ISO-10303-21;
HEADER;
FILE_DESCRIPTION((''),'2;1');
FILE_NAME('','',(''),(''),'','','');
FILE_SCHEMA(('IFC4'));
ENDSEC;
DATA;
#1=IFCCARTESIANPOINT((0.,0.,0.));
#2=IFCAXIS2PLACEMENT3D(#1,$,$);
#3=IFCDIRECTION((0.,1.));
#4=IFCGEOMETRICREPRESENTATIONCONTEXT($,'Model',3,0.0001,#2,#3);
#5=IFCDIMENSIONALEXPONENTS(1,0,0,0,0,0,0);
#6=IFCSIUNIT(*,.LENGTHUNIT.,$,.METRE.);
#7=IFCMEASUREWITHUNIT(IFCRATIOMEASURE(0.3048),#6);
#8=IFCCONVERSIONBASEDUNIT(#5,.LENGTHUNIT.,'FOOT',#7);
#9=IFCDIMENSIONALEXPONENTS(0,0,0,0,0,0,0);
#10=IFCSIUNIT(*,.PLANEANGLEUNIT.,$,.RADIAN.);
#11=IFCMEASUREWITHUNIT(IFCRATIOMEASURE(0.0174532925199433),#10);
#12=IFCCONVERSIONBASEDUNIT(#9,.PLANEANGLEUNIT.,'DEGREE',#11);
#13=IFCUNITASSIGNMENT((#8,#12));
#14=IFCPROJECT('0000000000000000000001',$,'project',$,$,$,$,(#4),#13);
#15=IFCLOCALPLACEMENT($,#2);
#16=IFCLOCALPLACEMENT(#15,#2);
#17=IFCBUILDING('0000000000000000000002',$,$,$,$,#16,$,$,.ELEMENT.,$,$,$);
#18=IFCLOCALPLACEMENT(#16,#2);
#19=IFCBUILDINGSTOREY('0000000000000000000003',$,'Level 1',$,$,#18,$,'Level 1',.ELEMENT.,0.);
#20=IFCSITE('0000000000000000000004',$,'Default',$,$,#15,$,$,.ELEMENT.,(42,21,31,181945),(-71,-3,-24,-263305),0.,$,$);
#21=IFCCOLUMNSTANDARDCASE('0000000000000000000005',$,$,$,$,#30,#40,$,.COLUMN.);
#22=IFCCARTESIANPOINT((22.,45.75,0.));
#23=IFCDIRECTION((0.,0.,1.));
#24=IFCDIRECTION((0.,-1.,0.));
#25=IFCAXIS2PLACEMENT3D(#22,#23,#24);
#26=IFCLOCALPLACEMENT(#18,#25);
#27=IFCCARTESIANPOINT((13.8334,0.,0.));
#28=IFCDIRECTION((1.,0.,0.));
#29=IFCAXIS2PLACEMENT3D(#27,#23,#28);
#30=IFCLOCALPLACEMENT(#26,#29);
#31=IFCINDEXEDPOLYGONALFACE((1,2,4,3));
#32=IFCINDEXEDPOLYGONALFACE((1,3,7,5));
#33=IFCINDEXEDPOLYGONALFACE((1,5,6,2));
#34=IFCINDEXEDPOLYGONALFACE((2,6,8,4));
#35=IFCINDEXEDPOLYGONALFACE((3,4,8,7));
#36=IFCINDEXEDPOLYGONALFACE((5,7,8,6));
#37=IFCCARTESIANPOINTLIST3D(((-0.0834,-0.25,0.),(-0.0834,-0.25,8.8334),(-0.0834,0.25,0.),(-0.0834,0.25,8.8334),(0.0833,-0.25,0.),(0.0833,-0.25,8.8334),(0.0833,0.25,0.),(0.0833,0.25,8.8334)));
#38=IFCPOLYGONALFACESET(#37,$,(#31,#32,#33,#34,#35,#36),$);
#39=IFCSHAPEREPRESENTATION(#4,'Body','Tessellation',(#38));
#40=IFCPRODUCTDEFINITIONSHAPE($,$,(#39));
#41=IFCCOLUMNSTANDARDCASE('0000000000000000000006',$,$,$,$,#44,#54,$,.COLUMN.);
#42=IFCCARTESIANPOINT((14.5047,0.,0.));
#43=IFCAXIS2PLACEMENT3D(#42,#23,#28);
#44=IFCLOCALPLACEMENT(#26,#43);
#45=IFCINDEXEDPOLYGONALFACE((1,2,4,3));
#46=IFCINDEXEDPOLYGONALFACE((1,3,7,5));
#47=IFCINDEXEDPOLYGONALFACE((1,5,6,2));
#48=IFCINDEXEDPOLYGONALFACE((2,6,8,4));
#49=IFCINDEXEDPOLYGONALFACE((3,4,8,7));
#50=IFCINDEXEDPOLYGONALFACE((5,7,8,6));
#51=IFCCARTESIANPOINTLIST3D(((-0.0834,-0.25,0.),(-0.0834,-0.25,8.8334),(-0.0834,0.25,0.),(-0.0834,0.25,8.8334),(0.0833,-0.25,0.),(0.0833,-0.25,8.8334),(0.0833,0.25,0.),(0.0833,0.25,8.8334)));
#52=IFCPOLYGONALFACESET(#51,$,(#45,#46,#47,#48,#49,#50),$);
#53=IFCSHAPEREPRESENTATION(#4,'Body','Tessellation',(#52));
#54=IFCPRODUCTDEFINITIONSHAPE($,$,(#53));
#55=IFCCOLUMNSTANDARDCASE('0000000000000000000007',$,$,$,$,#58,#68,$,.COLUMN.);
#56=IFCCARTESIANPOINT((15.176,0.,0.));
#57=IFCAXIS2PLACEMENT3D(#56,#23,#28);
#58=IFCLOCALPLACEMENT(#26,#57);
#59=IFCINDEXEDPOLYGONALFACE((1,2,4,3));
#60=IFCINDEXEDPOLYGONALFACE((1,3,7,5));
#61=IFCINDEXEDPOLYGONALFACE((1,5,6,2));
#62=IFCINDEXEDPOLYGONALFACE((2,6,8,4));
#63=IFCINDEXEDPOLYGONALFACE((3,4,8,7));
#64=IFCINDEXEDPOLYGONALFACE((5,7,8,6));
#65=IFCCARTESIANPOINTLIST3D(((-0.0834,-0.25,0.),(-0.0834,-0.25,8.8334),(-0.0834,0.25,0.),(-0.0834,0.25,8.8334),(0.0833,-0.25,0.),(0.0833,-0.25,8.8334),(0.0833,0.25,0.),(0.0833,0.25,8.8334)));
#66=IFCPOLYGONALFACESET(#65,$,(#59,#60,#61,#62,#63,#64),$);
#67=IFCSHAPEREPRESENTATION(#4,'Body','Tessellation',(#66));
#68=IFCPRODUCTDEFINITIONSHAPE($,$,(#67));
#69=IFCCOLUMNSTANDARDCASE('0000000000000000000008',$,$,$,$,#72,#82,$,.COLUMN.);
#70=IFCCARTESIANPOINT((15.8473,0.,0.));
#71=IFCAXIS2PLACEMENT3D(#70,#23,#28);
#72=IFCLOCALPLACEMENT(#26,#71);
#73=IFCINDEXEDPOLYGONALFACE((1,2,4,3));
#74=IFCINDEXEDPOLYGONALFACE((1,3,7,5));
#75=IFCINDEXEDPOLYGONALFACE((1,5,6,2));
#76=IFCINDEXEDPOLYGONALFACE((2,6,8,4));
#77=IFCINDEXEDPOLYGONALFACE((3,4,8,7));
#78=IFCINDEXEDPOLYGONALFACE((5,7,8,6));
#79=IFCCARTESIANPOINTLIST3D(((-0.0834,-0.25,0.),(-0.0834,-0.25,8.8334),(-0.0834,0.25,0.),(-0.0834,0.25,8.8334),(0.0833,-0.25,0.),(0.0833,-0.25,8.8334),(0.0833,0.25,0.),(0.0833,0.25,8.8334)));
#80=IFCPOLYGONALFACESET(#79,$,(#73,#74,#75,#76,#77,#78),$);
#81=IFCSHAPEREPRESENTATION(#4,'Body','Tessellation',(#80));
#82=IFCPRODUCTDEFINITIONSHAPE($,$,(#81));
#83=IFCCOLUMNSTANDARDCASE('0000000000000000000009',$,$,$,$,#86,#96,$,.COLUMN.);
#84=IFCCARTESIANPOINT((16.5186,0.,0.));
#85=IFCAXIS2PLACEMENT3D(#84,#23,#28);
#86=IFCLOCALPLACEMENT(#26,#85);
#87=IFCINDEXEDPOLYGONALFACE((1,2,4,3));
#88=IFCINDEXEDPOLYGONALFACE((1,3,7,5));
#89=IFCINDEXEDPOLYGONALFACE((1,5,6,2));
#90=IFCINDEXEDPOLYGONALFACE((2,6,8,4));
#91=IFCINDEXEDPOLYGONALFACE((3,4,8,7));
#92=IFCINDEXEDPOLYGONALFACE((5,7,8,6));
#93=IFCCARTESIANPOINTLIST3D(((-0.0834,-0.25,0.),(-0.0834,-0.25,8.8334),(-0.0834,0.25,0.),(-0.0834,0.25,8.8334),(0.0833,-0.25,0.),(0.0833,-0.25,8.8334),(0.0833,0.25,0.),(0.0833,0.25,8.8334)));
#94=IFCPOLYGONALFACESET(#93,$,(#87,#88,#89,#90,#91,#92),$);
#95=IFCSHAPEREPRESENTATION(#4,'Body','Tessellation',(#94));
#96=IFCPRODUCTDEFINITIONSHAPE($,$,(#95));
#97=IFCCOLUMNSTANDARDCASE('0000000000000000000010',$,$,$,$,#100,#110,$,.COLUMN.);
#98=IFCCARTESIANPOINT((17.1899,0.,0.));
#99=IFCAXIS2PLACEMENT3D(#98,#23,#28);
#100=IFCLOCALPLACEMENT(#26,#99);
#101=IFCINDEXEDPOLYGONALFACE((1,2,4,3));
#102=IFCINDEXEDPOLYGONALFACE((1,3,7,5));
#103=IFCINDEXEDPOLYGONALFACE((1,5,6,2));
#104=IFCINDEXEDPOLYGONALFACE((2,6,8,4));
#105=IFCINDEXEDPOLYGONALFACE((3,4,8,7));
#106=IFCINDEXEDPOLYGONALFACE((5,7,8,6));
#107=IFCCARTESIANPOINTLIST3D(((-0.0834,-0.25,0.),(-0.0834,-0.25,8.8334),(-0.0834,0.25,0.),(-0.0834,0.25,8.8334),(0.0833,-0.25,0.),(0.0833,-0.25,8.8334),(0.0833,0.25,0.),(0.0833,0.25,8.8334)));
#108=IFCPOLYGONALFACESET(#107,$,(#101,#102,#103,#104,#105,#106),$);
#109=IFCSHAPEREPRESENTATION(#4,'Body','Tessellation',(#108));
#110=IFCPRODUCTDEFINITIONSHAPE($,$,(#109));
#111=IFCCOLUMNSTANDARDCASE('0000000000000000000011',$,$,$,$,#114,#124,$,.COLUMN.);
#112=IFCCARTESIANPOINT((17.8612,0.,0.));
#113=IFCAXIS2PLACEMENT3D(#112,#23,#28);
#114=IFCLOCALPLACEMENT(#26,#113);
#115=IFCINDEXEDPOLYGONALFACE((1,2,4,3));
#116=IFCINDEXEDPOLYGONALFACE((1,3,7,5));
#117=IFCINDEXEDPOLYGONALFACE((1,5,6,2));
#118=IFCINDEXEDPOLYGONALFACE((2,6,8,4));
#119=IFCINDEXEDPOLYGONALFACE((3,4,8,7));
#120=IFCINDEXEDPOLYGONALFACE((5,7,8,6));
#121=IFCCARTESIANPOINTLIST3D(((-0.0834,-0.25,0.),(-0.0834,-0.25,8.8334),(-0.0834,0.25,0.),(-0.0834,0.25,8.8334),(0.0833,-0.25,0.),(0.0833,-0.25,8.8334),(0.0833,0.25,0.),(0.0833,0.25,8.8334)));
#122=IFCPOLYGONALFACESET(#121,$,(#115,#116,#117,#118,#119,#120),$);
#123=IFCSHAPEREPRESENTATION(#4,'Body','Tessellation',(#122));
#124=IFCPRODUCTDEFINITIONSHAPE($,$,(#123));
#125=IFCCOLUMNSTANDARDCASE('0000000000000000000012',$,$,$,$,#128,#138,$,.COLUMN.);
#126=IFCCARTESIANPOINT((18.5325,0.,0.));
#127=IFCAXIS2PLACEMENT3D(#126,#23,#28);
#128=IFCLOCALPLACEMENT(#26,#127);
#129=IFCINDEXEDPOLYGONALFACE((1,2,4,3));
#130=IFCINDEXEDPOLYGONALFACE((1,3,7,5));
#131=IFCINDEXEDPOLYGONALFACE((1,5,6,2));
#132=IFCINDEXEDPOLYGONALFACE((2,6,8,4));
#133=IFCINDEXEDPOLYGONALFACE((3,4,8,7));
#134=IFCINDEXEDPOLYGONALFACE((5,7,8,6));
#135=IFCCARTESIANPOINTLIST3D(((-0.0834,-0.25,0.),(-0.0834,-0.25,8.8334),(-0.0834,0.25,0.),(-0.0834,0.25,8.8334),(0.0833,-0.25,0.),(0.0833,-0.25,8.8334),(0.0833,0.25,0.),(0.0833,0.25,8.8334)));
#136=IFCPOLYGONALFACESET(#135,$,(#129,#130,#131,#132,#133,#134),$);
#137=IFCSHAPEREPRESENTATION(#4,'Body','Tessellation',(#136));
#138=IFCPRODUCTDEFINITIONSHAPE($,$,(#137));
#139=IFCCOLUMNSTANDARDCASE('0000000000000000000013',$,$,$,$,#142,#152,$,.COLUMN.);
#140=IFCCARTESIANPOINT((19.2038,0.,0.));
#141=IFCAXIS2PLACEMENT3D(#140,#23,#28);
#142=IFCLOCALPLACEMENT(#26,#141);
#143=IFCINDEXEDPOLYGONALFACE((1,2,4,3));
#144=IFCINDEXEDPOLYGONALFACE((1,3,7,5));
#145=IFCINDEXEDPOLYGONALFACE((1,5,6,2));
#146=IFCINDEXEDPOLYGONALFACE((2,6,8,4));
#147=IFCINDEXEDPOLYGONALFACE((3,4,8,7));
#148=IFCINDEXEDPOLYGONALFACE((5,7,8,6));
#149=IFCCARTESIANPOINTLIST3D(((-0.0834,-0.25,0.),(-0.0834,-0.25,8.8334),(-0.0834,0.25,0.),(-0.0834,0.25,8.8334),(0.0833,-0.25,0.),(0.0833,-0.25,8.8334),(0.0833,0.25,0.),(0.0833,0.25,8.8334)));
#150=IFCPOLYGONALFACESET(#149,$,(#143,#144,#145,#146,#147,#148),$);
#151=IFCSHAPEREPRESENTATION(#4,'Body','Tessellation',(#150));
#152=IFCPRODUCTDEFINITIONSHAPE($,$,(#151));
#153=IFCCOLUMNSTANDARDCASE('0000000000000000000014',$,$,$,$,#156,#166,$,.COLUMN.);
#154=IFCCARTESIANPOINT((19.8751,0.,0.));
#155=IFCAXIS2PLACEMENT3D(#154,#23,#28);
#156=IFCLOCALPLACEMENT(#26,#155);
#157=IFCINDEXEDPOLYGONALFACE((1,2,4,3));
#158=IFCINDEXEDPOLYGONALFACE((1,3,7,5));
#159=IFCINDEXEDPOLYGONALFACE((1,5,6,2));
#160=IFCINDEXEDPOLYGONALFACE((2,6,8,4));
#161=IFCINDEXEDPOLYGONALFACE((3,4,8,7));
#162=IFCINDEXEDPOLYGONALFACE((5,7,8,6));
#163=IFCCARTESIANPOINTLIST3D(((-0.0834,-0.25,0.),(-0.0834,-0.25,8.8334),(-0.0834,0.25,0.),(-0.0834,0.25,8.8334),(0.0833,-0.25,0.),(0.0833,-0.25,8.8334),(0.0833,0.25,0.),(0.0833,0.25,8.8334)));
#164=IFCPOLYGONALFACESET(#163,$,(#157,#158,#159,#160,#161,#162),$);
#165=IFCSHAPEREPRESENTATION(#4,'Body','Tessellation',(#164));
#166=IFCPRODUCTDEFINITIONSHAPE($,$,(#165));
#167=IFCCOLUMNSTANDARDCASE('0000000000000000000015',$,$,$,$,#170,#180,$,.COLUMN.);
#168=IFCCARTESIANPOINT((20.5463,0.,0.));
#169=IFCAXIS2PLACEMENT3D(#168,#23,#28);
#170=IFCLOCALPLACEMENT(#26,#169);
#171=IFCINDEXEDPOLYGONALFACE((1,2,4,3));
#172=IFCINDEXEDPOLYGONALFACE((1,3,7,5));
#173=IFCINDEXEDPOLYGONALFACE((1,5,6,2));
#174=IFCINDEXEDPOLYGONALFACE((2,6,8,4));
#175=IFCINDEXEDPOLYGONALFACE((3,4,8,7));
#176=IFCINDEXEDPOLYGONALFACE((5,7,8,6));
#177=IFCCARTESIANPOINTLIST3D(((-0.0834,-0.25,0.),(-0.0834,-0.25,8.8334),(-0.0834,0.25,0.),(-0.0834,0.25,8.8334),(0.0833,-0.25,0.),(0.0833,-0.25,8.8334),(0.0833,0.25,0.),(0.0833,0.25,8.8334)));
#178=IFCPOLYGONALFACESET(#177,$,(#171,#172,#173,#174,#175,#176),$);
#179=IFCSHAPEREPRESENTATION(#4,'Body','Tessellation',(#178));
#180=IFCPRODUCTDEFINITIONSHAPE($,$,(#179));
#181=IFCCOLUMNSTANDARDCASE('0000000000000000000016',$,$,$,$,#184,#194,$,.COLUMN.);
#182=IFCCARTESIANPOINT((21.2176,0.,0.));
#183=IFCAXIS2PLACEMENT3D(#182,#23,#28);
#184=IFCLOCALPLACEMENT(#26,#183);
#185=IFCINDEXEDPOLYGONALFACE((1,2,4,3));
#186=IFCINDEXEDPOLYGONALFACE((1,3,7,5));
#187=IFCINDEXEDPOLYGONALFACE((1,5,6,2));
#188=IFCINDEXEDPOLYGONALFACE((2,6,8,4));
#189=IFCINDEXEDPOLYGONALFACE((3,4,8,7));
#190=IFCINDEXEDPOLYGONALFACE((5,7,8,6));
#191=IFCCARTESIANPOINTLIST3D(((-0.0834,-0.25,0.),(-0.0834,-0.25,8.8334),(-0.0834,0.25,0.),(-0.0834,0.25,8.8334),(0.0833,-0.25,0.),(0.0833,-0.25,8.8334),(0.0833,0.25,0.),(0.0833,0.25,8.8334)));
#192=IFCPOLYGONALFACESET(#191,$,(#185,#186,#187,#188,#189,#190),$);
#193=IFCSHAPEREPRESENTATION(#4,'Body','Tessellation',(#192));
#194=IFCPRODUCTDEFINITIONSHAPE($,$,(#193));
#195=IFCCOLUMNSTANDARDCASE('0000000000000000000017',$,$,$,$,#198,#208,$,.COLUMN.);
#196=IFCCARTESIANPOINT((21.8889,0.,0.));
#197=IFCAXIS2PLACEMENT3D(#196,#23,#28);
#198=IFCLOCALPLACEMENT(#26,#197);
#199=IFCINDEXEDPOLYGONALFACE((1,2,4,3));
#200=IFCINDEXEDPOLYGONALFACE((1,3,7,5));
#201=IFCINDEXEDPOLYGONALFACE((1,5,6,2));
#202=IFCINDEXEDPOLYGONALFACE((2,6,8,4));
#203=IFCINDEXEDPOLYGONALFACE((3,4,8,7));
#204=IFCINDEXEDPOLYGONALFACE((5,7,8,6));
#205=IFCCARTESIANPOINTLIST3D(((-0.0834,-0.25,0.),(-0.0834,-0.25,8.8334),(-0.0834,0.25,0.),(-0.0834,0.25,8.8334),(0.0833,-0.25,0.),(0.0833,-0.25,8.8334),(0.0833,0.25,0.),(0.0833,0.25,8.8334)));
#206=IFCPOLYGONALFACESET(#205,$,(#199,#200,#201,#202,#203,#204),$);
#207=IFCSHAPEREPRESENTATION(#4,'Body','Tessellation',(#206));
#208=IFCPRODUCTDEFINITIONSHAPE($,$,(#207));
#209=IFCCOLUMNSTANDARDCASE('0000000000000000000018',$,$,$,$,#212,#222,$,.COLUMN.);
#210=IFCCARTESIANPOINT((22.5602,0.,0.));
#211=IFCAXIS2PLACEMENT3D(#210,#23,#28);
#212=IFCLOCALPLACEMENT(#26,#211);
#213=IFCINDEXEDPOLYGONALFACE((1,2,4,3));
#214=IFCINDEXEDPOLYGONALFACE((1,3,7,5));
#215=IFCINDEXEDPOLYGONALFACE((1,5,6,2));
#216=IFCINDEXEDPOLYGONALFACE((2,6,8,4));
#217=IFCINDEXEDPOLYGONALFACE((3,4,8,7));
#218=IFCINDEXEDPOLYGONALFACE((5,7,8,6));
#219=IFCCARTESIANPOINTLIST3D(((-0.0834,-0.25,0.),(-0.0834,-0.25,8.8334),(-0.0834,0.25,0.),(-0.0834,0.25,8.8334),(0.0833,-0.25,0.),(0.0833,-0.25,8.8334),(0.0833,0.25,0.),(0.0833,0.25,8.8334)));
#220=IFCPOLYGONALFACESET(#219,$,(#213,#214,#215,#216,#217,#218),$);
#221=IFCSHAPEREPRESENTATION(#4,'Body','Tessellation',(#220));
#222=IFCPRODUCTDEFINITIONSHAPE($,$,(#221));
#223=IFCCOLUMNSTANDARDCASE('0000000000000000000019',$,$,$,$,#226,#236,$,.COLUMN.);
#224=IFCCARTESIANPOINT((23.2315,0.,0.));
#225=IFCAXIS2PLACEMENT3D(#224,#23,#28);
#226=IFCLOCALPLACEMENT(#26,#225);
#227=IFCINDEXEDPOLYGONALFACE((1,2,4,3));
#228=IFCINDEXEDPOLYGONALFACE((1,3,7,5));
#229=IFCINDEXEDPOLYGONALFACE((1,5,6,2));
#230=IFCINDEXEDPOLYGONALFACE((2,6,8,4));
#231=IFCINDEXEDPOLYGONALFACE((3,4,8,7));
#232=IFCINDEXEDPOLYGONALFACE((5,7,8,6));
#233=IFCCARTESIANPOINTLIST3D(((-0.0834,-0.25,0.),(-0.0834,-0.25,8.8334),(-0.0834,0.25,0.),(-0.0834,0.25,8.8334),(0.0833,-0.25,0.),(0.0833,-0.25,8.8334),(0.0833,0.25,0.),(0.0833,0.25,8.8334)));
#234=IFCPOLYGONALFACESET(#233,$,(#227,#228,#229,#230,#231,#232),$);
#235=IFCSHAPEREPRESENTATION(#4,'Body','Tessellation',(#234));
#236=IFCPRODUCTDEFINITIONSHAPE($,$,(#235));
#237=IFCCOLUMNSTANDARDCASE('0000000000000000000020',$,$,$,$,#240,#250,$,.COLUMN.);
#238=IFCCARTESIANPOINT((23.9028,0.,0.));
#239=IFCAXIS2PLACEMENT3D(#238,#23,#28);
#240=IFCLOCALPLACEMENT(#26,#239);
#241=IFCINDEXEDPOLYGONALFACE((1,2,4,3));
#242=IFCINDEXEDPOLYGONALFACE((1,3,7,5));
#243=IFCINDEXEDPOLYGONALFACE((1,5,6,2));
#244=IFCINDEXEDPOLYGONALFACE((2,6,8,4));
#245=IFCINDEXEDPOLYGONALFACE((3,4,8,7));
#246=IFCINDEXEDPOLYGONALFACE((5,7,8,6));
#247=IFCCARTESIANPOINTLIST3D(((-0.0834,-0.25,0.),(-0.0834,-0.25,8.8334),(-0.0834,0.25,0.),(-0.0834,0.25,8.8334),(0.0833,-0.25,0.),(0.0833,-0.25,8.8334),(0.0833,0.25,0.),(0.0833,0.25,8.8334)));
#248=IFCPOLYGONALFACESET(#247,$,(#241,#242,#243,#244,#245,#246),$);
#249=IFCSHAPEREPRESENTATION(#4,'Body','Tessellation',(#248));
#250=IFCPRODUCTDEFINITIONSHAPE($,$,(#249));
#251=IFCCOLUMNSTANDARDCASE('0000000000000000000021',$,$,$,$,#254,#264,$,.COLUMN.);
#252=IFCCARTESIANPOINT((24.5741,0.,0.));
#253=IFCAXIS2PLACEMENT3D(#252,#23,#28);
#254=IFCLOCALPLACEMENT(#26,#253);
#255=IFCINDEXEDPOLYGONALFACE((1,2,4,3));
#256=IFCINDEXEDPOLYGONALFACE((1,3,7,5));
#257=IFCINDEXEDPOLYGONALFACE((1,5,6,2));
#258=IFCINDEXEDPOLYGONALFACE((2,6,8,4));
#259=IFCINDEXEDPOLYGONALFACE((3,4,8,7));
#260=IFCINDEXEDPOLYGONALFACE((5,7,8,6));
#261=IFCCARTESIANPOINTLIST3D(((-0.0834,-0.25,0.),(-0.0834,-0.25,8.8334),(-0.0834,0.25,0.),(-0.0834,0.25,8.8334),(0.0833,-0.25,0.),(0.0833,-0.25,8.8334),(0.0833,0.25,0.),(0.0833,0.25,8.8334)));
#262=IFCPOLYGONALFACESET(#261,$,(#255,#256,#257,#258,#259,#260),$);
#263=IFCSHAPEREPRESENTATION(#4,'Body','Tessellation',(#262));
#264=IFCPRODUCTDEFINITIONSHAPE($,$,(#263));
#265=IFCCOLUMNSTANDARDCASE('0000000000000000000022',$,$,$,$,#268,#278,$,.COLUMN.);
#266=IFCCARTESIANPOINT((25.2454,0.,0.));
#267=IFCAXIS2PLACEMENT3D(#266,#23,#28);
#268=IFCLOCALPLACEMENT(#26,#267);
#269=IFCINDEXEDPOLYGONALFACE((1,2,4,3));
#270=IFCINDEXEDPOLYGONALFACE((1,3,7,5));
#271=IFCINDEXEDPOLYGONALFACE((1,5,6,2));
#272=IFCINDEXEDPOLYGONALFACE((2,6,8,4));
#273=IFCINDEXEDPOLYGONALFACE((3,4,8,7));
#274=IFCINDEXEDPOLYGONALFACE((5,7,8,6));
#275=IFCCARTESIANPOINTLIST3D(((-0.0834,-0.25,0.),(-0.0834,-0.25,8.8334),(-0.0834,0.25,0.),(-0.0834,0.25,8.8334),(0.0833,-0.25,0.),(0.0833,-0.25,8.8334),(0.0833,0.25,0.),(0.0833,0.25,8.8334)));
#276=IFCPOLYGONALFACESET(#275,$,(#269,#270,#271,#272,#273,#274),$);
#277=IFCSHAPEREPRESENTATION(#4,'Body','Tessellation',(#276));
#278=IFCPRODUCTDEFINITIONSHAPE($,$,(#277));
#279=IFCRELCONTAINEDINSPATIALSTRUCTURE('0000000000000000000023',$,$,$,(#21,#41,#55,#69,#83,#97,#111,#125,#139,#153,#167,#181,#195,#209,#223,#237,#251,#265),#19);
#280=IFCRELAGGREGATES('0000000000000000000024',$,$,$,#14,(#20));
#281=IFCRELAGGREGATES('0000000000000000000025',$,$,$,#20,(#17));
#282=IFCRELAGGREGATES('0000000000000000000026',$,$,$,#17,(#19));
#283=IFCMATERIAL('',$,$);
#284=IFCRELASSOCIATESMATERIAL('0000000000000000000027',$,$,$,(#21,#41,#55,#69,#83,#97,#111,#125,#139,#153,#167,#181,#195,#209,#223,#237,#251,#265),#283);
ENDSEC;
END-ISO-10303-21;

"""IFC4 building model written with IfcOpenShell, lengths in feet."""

from ifc_helpers import new_model, entity, si_unit, converted_unit, direction, frame, origin, place, context, project, spatial, rectangle, extrude, material, element, save


model = new_model("IFC4")

# Units and contexts
model_context = context("Model", 3, precision=0.0001, world=origin(), true_north=direction((0.0, 1.0)))
ifc_project = project(units=[converted_unit("LENGTHUNIT", "FOOT", entity("IfcRatioMeasure", 0.3048), si_unit("LENGTHUNIT", "METRE"), dimensions=[1, 0, 0, 0, 0, 0, 0]), converted_unit("PLANEANGLEUNIT", "DEGREE", entity("IfcRatioMeasure", 0.0174532925199433), si_unit("PLANEANGLEUNIT", "RADIAN"), dimensions=[0, 0, 0, 0, 0, 0, 0])], contexts=[model_context])

# Site, building, storey
site_placement = place(None, origin())
site = spatial("IfcSite", under=ifc_project, at=site_placement, Name="Default", CompositionType="ELEMENT", RefLatitude=(42, 21, 31, 181945), RefLongitude=(-71, -3, -24, -263305), RefElevation=0.0)
building_placement = place(site_placement, origin())
building = spatial("IfcBuilding", under=site, at=building_placement, CompositionType="ELEMENT")
storey_placement = place(building_placement, origin())
storey = spatial("IfcBuildingStorey", under=building, at=storey_placement, Name="Level 1", LongName="Level 1", CompositionType="ELEMENT", Elevation=0.0)

# Columns
ifc_material_1 = material(Name="")
placement = place(storey_placement, frame((22.0, 45.75, 0.0), z_axis=(0.0, 0.0, 1.0), x_axis=(0.0, -1.0, 0.0)))
for number, where, z_axis, x_axis in (
    (1, (13.8334, 0.0, 0.0), (0.0, 0.0, 1.0), (1.0, 0.0, 0.0)),
    (2, (14.5047, 0.0, 0.0), (0.0, 0.0, 1.0), (1.0, 0.0, 0.0)),
    (3, (15.176, 0.0, 0.0), (0.0, 0.0, 1.0), (1.0, 0.0, 0.0)),
    (4, (15.8473, 0.0, 0.0), (0.0, 0.0, 1.0), (1.0, 0.0, 0.0)),
    (5, (16.5186, 0.0, 0.0), (0.0, 0.0, 1.0), (1.0, 0.0, 0.0)),
    (6, (17.1899, 0.0, 0.0), (0.0, 0.0, 1.0), (1.0, 0.0, 0.0)),
    (7, (17.8612, 0.0, 0.0), (0.0, 0.0, 1.0), (1.0, 0.0, 0.0)),
    (8, (18.5325, 0.0, 0.0), (0.0, 0.0, 1.0), (1.0, 0.0, 0.0)),
    (9, (19.2038, 0.0, 0.0), (0.0, 0.0, 1.0), (1.0, 0.0, 0.0)),
    (10, (19.8751, 0.0, 0.0), (0.0, 0.0, 1.0), (1.0, 0.0, 0.0)),
    (11, (20.5463, 0.0, 0.0), (0.0, 0.0, 1.0), (1.0, 0.0, 0.0)),
    (12, (21.2176, 0.0, 0.0), (0.0, 0.0, 1.0), (1.0, 0.0, 0.0)),
    (13, (21.8889, 0.0, 0.0), (0.0, 0.0, 1.0), (1.0, 0.0, 0.0)),
    (14, (22.5602, 0.0, 0.0), (0.0, 0.0, 1.0), (1.0, 0.0, 0.0)),
    (15, (23.2315, 0.0, 0.0), (0.0, 0.0, 1.0), (1.0, 0.0, 0.0)),
    (16, (23.9028, 0.0, 0.0), (0.0, 0.0, 1.0), (1.0, 0.0, 0.0)),
    (17, (24.5741, 0.0, 0.0), (0.0, 0.0, 1.0), (1.0, 0.0, 0.0)),
    (18, (25.2454, 0.0, 0.0), (0.0, 0.0, 1.0), (1.0, 0.0, 0.0)),
):
    element("IfcColumnStandardCase", number, at=place(placement, frame(where, z_axis=z_axis, x_axis=x_axis)), inside=storey, material=ifc_material_1, PredefinedType="COLUMN", context=model_context, shape_type="SweptSolid", body=[
        extrude(rectangle(XDim=0.1667, YDim=0.5), origin(), (0.0, 0.0, 1.0), 8.8334),
    ])

save(model, "model.ifc")
